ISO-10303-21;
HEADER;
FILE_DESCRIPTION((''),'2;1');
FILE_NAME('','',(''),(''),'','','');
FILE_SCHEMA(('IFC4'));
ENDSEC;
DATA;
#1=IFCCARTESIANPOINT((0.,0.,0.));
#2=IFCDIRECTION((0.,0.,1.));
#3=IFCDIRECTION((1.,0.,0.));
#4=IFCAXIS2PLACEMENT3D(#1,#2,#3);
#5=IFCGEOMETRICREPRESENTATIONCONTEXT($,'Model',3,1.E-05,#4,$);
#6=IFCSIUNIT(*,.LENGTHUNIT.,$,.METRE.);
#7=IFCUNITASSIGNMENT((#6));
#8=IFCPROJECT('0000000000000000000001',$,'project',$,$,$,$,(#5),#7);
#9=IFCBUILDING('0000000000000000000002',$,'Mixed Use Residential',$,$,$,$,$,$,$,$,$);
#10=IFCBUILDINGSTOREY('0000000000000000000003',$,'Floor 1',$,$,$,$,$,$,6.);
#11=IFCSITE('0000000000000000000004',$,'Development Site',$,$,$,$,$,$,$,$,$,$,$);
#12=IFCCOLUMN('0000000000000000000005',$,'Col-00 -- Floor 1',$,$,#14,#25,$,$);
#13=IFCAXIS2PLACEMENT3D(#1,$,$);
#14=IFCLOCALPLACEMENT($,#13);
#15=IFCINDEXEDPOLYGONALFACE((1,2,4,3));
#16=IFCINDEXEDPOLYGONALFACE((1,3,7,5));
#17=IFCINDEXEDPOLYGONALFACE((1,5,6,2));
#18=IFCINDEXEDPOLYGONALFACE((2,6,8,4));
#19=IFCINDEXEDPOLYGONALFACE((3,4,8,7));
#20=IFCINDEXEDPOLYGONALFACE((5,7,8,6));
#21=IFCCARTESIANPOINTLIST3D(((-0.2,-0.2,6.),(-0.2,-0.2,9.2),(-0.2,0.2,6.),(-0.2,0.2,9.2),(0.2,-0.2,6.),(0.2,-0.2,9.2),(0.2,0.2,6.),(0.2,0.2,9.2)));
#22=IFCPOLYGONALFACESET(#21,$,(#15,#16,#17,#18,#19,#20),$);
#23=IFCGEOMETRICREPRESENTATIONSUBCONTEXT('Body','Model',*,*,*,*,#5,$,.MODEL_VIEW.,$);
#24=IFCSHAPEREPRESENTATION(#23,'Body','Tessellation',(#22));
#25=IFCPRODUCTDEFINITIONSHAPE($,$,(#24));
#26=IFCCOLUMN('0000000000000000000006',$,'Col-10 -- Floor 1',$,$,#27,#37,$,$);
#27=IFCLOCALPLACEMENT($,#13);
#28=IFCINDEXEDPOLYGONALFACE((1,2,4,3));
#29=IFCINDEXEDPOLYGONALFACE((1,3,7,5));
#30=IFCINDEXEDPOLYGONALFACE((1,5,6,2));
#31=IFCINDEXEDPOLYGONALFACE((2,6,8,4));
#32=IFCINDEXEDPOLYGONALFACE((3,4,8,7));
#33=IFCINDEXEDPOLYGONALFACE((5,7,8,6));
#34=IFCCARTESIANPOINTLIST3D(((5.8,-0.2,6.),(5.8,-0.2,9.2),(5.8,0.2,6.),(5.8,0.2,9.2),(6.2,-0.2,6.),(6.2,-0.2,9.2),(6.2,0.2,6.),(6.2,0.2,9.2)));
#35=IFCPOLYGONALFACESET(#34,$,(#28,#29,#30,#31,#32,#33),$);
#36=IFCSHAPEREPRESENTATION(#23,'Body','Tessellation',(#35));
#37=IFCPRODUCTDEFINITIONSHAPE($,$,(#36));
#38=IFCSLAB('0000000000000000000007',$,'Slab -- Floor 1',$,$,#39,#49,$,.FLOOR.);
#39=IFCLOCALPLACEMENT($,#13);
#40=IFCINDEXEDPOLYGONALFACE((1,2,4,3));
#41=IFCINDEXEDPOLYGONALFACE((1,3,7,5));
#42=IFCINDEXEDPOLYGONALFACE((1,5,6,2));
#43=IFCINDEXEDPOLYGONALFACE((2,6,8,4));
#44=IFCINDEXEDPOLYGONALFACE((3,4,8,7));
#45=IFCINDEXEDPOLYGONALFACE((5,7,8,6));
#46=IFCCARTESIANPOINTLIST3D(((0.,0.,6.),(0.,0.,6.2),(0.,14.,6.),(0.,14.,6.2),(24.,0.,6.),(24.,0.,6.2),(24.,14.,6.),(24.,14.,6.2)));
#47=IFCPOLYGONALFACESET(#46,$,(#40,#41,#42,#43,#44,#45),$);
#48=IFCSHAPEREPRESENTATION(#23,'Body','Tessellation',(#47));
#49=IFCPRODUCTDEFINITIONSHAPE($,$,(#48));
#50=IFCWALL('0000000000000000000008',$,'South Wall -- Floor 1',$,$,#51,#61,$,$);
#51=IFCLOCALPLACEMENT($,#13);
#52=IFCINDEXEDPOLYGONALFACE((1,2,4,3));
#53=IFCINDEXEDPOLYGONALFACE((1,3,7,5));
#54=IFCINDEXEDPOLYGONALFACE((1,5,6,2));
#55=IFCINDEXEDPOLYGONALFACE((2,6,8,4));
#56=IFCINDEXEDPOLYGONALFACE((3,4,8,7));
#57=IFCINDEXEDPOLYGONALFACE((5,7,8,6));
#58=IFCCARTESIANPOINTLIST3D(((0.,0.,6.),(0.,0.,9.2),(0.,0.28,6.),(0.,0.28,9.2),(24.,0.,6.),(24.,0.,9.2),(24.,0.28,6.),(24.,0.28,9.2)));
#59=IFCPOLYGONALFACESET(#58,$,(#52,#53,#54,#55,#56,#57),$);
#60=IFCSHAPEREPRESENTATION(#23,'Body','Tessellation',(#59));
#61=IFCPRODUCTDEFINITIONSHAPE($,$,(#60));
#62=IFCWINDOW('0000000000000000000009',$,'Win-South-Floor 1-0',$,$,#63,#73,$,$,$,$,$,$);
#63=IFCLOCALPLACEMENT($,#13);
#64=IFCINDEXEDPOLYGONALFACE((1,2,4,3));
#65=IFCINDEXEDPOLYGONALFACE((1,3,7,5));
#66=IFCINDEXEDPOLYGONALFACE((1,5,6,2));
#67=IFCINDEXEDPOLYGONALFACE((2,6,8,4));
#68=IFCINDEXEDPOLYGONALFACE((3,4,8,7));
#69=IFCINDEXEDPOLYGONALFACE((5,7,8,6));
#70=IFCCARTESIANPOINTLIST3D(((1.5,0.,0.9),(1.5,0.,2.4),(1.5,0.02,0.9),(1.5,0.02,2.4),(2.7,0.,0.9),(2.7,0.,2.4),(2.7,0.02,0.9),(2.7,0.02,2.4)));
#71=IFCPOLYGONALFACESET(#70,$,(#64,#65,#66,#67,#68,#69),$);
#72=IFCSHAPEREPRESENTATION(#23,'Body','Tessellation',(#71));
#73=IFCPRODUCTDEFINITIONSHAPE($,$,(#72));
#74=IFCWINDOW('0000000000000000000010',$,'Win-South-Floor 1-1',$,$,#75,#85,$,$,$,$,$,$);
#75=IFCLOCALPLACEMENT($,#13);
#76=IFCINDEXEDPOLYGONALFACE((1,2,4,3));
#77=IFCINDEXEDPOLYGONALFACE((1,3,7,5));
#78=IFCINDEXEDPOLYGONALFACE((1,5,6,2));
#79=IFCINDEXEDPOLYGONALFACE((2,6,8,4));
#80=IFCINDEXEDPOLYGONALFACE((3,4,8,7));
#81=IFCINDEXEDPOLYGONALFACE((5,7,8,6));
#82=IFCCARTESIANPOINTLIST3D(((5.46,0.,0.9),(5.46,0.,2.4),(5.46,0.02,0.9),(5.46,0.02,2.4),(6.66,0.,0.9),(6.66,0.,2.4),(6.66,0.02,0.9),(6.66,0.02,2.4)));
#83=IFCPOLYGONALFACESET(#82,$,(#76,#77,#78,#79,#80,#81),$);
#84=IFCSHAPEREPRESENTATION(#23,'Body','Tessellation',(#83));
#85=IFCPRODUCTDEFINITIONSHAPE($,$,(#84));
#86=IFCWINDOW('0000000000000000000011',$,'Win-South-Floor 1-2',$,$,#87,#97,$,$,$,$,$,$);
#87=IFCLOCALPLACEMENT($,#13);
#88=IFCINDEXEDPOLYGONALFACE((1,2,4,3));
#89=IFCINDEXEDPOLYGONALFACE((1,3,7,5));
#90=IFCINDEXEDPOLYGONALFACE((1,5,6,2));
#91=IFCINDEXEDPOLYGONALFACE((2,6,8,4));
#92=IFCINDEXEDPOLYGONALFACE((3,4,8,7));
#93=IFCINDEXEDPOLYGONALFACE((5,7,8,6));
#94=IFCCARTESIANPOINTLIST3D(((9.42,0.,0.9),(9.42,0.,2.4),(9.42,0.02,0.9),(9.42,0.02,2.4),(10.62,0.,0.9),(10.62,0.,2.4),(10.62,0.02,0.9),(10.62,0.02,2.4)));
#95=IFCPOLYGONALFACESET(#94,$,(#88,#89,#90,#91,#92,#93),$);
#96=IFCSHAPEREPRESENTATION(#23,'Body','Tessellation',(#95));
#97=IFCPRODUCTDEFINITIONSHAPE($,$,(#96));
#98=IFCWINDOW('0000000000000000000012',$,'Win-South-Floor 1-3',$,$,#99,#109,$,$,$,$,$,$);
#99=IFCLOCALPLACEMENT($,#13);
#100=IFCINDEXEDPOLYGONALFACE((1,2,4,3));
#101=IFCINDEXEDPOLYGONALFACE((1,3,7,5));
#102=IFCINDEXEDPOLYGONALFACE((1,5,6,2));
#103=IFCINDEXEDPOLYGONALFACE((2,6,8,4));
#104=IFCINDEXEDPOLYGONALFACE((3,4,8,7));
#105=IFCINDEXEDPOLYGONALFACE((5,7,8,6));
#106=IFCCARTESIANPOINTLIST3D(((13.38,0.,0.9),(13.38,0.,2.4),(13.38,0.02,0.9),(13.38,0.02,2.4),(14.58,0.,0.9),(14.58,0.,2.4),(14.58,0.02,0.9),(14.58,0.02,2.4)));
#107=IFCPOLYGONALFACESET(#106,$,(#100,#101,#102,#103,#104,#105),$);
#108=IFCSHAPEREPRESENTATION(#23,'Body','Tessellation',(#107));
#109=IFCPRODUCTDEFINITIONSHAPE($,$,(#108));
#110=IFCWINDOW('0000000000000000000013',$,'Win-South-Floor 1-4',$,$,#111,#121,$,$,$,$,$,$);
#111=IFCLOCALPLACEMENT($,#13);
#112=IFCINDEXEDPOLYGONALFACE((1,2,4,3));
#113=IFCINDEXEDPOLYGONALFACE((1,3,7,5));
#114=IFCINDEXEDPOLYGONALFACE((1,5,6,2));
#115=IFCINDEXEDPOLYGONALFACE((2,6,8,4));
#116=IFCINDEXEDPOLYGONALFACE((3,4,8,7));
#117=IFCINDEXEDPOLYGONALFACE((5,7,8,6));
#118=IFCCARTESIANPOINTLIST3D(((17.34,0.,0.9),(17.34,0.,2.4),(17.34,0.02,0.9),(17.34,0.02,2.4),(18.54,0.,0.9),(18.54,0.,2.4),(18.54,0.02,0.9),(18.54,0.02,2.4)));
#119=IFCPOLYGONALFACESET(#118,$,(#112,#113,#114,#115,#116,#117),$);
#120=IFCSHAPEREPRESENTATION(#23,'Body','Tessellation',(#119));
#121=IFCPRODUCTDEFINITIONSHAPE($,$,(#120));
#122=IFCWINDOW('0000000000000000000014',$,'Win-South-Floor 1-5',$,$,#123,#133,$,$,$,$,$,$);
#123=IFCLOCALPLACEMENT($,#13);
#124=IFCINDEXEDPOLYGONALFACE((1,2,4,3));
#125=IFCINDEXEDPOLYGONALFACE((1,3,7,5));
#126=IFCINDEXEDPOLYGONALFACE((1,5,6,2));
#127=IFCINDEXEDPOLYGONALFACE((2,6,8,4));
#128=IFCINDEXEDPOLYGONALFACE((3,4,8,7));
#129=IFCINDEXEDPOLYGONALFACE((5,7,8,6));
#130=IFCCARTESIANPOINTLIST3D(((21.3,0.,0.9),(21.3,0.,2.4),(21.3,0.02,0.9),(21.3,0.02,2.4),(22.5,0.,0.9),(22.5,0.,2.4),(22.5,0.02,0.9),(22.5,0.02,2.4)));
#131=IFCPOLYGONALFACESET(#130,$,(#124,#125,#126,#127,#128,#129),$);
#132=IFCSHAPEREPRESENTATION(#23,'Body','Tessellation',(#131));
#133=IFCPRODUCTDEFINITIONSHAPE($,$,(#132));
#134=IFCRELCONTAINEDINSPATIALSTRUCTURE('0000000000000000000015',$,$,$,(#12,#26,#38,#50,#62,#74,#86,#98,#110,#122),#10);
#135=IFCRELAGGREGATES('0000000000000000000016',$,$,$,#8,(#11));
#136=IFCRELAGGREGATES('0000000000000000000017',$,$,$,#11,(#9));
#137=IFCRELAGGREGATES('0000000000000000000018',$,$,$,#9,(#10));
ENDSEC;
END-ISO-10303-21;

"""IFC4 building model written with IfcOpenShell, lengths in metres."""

from ifc_helpers import new_model, si_unit, frame, origin_with_axes, place, context, subcontext, project, spatial, indexed_curve, rectangle, outline, extrude, element, fill, save


model = new_model("IFC4")

# Units and contexts
model_context = context("Model", 3, precision=1e-05, world=origin_with_axes())
body_context = subcontext(model_context, "Body", "Model", "MODEL_VIEW")
ifc_project = project(units=[si_unit("LENGTHUNIT", "METRE")], contexts=[model_context])

# Site, building, storey
site = spatial("IfcSite", under=ifc_project, Name="Development Site")
building = spatial("IfcBuilding", under=site, Name="Mixed Use Residential")
storey = spatial("IfcBuildingStorey", under=building, Name="Floor 1", Elevation=6.0)

# Columns
for number, where, z_axis, x_axis, name in (
    (1, (0.0, 0.0, 6.0), (0.0, 0.0, 1.0), (1.0, 0.0, 0.0), "Col-00 -- Floor 1"),
    (2, (6.0, 0.0, 6.0), (0.0, 0.0, 1.0), (1.0, 0.0, 0.0), "Col-10 -- Floor 1"),
):
    element("IfcColumn", number, at=place(None, frame(where, z_axis=z_axis, x_axis=x_axis)), inside=storey, Name=name, context=body_context, shape_type="SweptSolid", body=[
        extrude(rectangle(XDim=0.4, YDim=0.4), origin_with_axes(), (0.0, 0.0, 1.0), 3.2),
    ])

# Slab
slab_placement = place(None, frame((0.0, 0.0, 6.0), z_axis=(0.0, 0.0, 1.0), x_axis=(1.0, 0.0, 0.0)))
element("IfcSlab", 3, at=slab_placement, inside=storey, Name="Slab -- Floor 1", PredefinedType="FLOOR", context=body_context, shape_type="SweptSolid", body=[
    extrude(outline(indexed_curve([(0.0, 0.0), (24.0, 0.0), (24.0, 14.0), (0.0, 14.0), (0.0, 0.0)])), None, (0.0, 0.0, 1.0), 0.2),
])

# Wall, openings, windows
wall_1_placement = place(None, frame((0.0, 0.0, 6.0), z_axis=(0.0, 0.0, 1.0), x_axis=(1.0, 0.0, 0.0)))
wall_1 = element("IfcWall", 4, at=wall_1_placement, inside=storey, Name="South Wall -- Floor 1", context=body_context, shape_type="SweptSolid", body=[
    extrude(outline(indexed_curve([(0.0, 0.0), (0.0, 0.28), (24.0, 0.28), (24.0, 0.0), (0.0, 0.0)], self_intersect=False)), origin_with_axes(), (0.0, 0.0, 1.0), 3.2),
])
opening_1_placement = place(wall_1_placement, frame((1.5, 0.0, -5.1), z_axis=(0.0, 0.0, 1.0), x_axis=(1.0, 0.0, 0.0)))
opening_1 = element("IfcOpeningElement", 5, at=opening_1_placement, cuts=wall_1, context=body_context, shape_type="SweptSolid", body=[
    extrude(outline(indexed_curve([(0.0, 0.0), (0.0, 0.28), (1.2, 0.28), (1.2, 0.0), (0.0, 0.0)], self_intersect=False)), origin_with_axes(), (0.0, 0.0, 1.0), 1.5),
])
opening_2_placement = place(wall_1_placement, frame((5.46, 0.0, -5.1), z_axis=(0.0, 0.0, 1.0), x_axis=(1.0, 0.0, 0.0)))
opening_2 = element("IfcOpeningElement", 6, at=opening_2_placement, cuts=wall_1, context=body_context, shape_type="SweptSolid", body=[
    extrude(outline(indexed_curve([(0.0, 0.0), (0.0, 0.28), (1.2, 0.28), (1.2, 0.0), (0.0, 0.0)], self_intersect=False)), origin_with_axes(), (0.0, 0.0, 1.0), 1.5),
])
opening_3_placement = place(wall_1_placement, frame((9.42, 0.0, -5.1), z_axis=(0.0, 0.0, 1.0), x_axis=(1.0, 0.0, 0.0)))
opening_3 = element("IfcOpeningElement", 7, at=opening_3_placement, cuts=wall_1, context=body_context, shape_type="SweptSolid", body=[
    extrude(outline(indexed_curve([(0.0, 0.0), (0.0, 0.28), (1.2, 0.28), (1.2, 0.0), (0.0, 0.0)], self_intersect=False)), origin_with_axes(), (0.0, 0.0, 1.0), 1.5),
])
opening_4_placement = place(wall_1_placement, frame((13.38, 0.0, -5.1), z_axis=(0.0, 0.0, 1.0), x_axis=(1.0, 0.0, 0.0)))
opening_4 = element("IfcOpeningElement", 8, at=opening_4_placement, cuts=wall_1, context=body_context, shape_type="SweptSolid", body=[
    extrude(outline(indexed_curve([(0.0, 0.0), (0.0, 0.28), (1.2, 0.28), (1.2, 0.0), (0.0, 0.0)], self_intersect=False)), origin_with_axes(), (0.0, 0.0, 1.0), 1.5),
])
opening_5_placement = place(wall_1_placement, frame((17.34, 0.0, -5.1), z_axis=(0.0, 0.0, 1.0), x_axis=(1.0, 0.0, 0.0)))
opening_5 = element("IfcOpeningElement", 9, at=opening_5_placement, cuts=wall_1, context=body_context, shape_type="SweptSolid", body=[
    extrude(outline(indexed_curve([(0.0, 0.0), (0.0, 0.28), (1.2, 0.28), (1.2, 0.0), (0.0, 0.0)], self_intersect=False)), origin_with_axes(), (0.0, 0.0, 1.0), 1.5),
])
opening_6_placement = place(wall_1_placement, frame((21.3, 0.0, -5.1), z_axis=(0.0, 0.0, 1.0), x_axis=(1.0, 0.0, 0.0)))
opening_6 = element("IfcOpeningElement", 10, at=opening_6_placement, cuts=wall_1, context=body_context, shape_type="SweptSolid", body=[
    extrude(outline(indexed_curve([(0.0, 0.0), (0.0, 0.28), (1.2, 0.28), (1.2, 0.0), (0.0, 0.0)], self_intersect=False)), origin_with_axes(), (0.0, 0.0, 1.0), 1.5),
])
window_1_placement = place(None, frame((1.5, 0.0, 0.9), z_axis=(0.0, 0.0, 1.0), x_axis=(1.0, 0.0, 0.0)))
window_1 = element("IfcWindow", 11, at=window_1_placement, inside=storey, Name="Win-South-Floor 1-0", context=body_context, shape_type="SweptSolid", body=[
    extrude(outline(indexed_curve([(0.0, 0.0), (0.0, 0.02), (1.2, 0.02), (1.2, 0.0), (0.0, 0.0)], self_intersect=False)), origin_with_axes(), (0.0, 0.0, 1.0), 1.5),
])
fill(opening_1, window_1)
window_2_placement = place(None, frame((5.46, 0.0, 0.9), z_axis=(0.0, 0.0, 1.0), x_axis=(1.0, 0.0, 0.0)))
window_2 = element("IfcWindow", 12, at=window_2_placement, inside=storey, Name="Win-South-Floor 1-1", context=body_context, shape_type="SweptSolid", body=[
    extrude(outline(indexed_curve([(0.0, 0.0), (0.0, 0.02), (1.2, 0.02), (1.2, 0.0), (0.0, 0.0)], self_intersect=False)), origin_with_axes(), (0.0, 0.0, 1.0), 1.5),
])
fill(opening_2, window_2)
window_3_placement = place(None, frame((9.42, 0.0, 0.9), z_axis=(0.0, 0.0, 1.0), x_axis=(1.0, 0.0, 0.0)))
window_3 = element("IfcWindow", 13, at=window_3_placement, inside=storey, Name="Win-South-Floor 1-2", context=body_context, shape_type="SweptSolid", body=[
    extrude(outline(indexed_curve([(0.0, 0.0), (0.0, 0.02), (1.2, 0.02), (1.2, 0.0), (0.0, 0.0)], self_intersect=False)), origin_with_axes(), (0.0, 0.0, 1.0), 1.5),
])
fill(opening_3, window_3)
window_4_placement = place(None, frame((13.38, 0.0, 0.9), z_axis=(0.0, 0.0, 1.0), x_axis=(1.0, 0.0, 0.0)))
window_4 = element("IfcWindow", 14, at=window_4_placement, inside=storey, Name="Win-South-Floor 1-3", context=body_context, shape_type="SweptSolid", body=[
    extrude(outline(indexed_curve([(0.0, 0.0), (0.0, 0.02), (1.2, 0.02), (1.2, 0.0), (0.0, 0.0)], self_intersect=False)), origin_with_axes(), (0.0, 0.0, 1.0), 1.5),
])
fill(opening_4, window_4)
window_5_placement = place(None, frame((17.34, 0.0, 0.9), z_axis=(0.0, 0.0, 1.0), x_axis=(1.0, 0.0, 0.0)))
window_5 = element("IfcWindow", 15, at=window_5_placement, inside=storey, Name="Win-South-Floor 1-4", context=body_context, shape_type="SweptSolid", body=[
    extrude(outline(indexed_curve([(0.0, 0.0), (0.0, 0.02), (1.2, 0.02), (1.2, 0.0), (0.0, 0.0)], self_intersect=False)), origin_with_axes(), (0.0, 0.0, 1.0), 1.5),
])
fill(opening_5, window_5)
window_6_placement = place(None, frame((21.3, 0.0, 0.9), z_axis=(0.0, 0.0, 1.0), x_axis=(1.0, 0.0, 0.0)))
window_6 = element("IfcWindow", 16, at=window_6_placement, inside=storey, Name="Win-South-Floor 1-5", context=body_context, shape_type="SweptSolid", body=[
    extrude(outline(indexed_curve([(0.0, 0.0), (0.0, 0.02), (1.2, 0.02), (1.2, 0.0), (0.0, 0.0)], self_intersect=False)), origin_with_axes(), (0.0, 0.0, 1.0), 1.5),
])
fill(opening_6, window_6)

save(model, "model.ifc")
